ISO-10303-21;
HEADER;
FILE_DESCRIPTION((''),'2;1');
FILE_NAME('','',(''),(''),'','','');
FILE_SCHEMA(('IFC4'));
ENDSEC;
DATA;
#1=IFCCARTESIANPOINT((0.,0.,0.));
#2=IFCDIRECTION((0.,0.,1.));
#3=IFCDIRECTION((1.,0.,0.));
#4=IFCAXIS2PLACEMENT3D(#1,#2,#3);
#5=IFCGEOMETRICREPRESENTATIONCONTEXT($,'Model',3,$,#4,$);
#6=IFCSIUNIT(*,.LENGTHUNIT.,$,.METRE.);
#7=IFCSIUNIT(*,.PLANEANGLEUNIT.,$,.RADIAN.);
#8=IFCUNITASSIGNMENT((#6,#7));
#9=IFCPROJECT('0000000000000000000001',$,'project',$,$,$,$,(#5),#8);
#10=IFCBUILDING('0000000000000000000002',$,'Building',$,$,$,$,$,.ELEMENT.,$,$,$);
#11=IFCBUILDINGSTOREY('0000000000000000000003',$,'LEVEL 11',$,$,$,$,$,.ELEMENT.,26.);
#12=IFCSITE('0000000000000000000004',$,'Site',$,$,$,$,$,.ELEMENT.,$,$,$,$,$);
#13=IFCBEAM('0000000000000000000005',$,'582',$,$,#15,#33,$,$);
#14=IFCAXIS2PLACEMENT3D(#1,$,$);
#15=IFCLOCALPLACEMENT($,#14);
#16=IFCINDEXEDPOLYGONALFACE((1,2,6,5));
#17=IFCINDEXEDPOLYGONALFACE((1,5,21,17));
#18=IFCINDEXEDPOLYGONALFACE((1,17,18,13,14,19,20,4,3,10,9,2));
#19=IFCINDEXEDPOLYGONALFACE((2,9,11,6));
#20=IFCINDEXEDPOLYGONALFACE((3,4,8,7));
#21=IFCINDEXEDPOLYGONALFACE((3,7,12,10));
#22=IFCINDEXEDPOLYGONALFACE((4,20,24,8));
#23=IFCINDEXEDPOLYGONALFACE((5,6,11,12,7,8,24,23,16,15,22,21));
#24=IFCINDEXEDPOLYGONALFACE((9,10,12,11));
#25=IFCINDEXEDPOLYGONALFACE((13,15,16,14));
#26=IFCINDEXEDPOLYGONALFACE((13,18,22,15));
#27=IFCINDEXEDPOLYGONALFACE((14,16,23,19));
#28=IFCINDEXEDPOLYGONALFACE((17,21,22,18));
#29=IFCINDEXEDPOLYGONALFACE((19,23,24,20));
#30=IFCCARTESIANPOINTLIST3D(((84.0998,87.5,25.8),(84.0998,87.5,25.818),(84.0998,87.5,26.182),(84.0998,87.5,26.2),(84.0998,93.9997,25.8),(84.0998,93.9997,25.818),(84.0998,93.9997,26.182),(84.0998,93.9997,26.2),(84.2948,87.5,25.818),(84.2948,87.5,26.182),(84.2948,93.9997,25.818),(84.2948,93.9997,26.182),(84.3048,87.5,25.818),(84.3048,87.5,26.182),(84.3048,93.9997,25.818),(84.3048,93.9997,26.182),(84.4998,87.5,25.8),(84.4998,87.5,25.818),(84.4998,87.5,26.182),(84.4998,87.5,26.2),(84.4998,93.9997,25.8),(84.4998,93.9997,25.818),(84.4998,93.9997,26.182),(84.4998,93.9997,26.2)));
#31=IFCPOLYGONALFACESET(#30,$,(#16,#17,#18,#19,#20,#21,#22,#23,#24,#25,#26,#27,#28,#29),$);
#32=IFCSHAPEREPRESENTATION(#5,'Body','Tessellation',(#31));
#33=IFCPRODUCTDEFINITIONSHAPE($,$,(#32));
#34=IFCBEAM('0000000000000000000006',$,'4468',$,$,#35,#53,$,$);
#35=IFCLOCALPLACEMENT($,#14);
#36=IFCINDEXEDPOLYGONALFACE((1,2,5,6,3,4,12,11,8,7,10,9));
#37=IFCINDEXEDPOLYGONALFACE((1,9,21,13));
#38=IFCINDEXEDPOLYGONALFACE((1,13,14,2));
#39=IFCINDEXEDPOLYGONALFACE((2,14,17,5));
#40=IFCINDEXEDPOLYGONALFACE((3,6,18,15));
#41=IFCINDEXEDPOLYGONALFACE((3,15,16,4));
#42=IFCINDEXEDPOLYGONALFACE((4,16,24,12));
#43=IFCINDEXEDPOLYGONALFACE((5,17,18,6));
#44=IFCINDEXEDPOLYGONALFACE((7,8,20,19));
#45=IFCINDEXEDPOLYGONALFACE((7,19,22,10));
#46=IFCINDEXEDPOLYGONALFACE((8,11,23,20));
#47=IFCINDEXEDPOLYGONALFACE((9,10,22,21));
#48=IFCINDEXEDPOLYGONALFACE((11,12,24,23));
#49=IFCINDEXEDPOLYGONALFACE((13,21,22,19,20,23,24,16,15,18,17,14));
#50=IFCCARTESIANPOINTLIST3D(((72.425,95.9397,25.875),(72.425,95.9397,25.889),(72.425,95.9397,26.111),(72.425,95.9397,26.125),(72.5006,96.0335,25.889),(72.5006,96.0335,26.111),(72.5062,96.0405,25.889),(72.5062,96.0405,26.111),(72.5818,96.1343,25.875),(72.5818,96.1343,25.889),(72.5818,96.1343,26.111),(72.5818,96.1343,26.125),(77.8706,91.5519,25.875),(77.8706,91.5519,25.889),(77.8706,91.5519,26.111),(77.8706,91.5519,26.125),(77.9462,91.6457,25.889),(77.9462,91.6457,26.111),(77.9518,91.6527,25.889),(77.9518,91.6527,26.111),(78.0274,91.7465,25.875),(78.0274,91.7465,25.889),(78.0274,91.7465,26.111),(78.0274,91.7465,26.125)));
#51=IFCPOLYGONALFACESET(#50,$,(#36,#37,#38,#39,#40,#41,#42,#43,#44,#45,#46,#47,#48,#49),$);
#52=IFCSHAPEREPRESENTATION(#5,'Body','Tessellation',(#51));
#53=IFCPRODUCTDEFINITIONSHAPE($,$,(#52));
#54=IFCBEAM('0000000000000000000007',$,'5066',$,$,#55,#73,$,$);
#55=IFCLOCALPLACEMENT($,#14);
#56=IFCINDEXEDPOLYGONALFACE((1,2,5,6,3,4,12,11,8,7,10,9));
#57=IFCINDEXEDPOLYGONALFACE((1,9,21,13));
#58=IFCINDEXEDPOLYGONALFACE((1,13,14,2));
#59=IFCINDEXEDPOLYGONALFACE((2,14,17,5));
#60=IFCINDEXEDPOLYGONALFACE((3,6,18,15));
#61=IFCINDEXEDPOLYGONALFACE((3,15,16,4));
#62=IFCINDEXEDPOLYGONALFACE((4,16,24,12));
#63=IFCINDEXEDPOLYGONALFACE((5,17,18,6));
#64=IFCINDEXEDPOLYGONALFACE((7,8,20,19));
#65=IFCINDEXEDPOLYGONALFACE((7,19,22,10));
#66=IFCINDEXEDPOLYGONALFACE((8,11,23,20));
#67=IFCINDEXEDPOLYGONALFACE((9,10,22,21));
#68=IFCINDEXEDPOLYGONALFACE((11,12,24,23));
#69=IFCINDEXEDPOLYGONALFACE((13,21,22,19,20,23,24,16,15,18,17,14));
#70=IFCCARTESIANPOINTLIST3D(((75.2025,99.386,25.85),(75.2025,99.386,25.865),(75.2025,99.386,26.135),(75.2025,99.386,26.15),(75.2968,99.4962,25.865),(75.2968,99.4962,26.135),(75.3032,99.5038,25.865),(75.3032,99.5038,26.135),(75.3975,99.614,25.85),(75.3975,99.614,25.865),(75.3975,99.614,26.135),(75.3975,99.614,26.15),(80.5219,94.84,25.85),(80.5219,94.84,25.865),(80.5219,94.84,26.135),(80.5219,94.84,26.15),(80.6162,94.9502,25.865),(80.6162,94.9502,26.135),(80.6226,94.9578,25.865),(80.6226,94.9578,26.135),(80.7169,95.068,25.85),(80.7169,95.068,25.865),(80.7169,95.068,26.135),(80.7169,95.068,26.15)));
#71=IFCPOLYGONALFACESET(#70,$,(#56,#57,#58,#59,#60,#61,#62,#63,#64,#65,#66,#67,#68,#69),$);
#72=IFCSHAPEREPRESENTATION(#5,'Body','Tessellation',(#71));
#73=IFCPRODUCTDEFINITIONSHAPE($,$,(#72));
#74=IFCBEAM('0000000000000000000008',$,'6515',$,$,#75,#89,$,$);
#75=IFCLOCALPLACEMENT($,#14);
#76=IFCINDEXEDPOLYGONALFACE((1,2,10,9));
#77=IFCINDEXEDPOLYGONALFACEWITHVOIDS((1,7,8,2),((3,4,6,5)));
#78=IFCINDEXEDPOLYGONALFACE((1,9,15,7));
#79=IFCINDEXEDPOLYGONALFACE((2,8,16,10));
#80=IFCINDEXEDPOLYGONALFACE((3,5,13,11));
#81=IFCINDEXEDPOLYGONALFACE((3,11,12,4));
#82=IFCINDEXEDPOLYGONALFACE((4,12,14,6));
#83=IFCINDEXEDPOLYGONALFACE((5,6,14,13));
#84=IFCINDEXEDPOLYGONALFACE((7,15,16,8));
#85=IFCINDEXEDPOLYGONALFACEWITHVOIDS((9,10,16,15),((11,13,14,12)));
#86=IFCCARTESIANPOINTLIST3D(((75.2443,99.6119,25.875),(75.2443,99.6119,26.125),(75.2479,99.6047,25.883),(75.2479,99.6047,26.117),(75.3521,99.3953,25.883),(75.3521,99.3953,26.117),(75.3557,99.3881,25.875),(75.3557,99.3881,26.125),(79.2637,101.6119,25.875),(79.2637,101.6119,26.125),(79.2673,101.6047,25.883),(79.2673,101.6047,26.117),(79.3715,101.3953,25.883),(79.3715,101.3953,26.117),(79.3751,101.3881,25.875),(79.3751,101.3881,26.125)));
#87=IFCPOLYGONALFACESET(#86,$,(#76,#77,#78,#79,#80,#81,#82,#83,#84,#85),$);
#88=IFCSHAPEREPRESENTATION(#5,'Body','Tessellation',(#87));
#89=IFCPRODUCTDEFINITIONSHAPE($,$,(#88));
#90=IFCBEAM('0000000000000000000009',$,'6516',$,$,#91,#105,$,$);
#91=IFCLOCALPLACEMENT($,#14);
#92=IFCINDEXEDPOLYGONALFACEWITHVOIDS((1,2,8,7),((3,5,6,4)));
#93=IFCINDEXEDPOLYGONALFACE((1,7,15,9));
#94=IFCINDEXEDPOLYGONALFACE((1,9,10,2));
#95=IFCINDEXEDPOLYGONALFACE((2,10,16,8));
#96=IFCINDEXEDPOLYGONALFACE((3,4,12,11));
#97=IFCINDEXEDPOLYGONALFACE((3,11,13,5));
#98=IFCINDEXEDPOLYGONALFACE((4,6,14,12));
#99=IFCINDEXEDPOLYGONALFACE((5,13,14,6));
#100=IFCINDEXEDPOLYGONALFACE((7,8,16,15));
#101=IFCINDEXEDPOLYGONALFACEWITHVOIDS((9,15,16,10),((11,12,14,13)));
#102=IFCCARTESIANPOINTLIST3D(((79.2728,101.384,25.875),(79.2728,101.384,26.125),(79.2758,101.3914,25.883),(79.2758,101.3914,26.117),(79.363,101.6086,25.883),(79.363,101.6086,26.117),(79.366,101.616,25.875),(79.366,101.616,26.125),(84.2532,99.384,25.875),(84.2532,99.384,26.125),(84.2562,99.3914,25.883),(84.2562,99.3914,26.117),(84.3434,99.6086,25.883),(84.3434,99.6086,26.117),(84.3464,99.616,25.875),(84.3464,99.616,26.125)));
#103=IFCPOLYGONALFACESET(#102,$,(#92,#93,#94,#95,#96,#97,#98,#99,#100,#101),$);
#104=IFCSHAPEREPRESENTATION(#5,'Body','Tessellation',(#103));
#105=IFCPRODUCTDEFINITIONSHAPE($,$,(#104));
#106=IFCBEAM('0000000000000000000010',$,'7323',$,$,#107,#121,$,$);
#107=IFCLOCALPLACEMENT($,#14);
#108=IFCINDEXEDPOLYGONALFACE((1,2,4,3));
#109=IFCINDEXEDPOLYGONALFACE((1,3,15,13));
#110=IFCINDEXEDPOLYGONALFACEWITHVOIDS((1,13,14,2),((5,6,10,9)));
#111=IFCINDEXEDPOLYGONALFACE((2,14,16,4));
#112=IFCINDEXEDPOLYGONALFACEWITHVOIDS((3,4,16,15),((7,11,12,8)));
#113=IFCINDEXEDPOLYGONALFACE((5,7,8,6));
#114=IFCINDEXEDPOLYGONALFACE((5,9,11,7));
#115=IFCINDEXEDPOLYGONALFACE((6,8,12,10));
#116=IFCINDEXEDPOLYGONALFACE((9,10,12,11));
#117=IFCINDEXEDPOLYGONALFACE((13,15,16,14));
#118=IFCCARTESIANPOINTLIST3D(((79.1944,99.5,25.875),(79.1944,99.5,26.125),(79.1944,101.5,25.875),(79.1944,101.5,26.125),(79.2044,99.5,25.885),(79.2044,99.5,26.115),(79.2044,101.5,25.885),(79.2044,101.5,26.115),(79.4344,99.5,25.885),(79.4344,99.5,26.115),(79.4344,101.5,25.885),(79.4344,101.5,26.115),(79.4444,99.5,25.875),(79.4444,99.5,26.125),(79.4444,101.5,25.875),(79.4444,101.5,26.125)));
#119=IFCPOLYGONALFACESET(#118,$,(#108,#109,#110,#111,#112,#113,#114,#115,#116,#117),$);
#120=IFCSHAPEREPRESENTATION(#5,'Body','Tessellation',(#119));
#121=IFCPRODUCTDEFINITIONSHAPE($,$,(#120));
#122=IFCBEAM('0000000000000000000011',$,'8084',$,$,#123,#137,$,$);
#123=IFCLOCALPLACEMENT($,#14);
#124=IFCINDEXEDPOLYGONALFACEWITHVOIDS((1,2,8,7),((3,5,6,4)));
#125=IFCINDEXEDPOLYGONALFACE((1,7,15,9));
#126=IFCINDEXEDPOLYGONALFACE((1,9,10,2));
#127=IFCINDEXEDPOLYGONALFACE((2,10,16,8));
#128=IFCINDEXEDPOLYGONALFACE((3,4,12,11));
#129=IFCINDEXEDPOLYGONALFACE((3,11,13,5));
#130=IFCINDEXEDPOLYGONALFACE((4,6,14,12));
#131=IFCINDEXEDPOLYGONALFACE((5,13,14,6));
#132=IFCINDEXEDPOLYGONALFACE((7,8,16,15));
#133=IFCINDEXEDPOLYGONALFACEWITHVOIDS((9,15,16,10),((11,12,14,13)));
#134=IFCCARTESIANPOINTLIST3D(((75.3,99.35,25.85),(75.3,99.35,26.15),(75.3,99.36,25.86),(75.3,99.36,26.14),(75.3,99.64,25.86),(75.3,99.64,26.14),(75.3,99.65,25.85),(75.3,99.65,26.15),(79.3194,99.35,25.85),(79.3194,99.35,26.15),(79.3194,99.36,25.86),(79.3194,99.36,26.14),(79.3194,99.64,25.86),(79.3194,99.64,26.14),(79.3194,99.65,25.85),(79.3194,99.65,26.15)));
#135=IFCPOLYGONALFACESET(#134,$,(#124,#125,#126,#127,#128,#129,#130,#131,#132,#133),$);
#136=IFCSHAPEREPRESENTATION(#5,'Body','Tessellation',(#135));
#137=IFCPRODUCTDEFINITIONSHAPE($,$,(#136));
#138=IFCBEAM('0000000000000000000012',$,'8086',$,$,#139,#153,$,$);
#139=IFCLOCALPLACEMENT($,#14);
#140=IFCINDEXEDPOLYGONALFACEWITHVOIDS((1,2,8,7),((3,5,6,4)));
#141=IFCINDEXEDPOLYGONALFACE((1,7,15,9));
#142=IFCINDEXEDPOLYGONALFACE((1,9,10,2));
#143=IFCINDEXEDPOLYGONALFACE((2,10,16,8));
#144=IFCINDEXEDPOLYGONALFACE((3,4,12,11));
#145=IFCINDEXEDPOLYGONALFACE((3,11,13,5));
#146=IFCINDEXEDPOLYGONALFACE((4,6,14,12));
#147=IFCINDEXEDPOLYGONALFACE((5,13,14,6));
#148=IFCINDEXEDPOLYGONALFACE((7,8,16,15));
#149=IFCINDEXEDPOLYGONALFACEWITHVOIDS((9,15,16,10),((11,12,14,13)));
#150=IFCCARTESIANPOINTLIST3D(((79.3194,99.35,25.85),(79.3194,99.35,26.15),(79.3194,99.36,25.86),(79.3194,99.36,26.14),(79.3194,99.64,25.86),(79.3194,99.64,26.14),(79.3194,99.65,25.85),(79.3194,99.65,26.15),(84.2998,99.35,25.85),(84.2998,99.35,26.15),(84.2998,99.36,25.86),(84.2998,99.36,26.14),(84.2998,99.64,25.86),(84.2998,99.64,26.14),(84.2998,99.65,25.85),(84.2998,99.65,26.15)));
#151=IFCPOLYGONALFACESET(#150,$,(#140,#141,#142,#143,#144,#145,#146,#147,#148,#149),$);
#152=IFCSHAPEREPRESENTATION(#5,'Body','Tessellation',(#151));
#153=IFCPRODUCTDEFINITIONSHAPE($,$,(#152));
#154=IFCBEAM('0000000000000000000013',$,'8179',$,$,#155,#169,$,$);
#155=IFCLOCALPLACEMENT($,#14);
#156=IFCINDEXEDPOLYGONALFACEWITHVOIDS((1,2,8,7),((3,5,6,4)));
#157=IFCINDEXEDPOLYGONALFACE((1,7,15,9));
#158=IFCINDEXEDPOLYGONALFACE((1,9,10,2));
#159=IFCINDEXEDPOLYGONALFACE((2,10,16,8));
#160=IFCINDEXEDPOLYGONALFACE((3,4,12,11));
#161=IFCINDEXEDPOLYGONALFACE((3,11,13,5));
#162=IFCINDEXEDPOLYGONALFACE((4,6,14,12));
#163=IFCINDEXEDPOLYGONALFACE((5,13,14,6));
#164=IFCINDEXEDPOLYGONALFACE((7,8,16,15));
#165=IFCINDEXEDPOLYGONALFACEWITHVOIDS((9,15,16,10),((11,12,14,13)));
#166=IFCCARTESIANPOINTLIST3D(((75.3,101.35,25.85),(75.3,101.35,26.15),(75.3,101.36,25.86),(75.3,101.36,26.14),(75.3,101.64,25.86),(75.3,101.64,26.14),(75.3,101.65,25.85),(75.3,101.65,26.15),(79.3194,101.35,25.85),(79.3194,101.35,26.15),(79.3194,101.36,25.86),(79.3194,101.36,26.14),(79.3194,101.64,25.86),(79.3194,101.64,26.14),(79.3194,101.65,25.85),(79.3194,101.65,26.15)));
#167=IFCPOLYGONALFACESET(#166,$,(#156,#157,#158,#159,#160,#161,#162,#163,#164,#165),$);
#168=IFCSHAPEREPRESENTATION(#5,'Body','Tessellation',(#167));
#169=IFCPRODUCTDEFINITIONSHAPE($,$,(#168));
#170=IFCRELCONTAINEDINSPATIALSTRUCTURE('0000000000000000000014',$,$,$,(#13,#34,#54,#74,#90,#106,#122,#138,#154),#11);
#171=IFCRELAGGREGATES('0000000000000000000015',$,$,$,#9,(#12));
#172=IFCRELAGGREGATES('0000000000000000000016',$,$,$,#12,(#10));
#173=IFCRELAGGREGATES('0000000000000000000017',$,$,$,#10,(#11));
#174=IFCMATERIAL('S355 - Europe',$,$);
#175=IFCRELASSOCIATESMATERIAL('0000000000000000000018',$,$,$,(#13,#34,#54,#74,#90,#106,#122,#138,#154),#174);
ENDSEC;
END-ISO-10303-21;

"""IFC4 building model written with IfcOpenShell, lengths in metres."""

from ifc_helpers import new_model, si_unit, frame, origin_with_axes, origin_2d_with_axis, place, context, project, spatial, hollow_rectangle, i_section, extrude, material, material_profile, profile_set, profile_usage, element, save


model = new_model("IFC4")

# Units and contexts
model_context = context("Model", 3, world=origin_with_axes())
ifc_project = project(units=[si_unit("LENGTHUNIT", "METRE"), si_unit("PLANEANGLEUNIT", "RADIAN")], contexts=[model_context])

# Site, building, storey
site = spatial("IfcSite", under=ifc_project, Name="Site", CompositionType="ELEMENT")
building = spatial("IfcBuilding", under=site, Name="Building", CompositionType="ELEMENT")
storey = spatial("IfcBuildingStorey", under=building, Name="LEVEL 11", CompositionType="ELEMENT", Elevation=26.0)

# Shared definitions
ifc_material = material(Name="S355 - Europe")

# Beams
ifc_material_profile_1 = material_profile(ifc_material, i_section(OverallWidth=0.4, OverallDepth=0.4, WebThickness=0.01, FlangeThickness=0.018, at=origin_2d_with_axis()))
ifc_profile_set_1 = profile_set([ifc_material_profile_1])
ifc_profile_usage_1 = profile_usage(ifc_profile_set_1, cardinal=10)
beam_1_placement = place(None, frame((84.2998, 93.9997, 26.0), z_axis=(0.0, -1.0, 0.0), x_axis=(1.0, 0.0, 0.0)))
element("IfcBeam", 1, at=beam_1_placement, inside=storey, material=ifc_profile_usage_1, Name="582", context=model_context, shape_type="SweptSolid", body=[
    extrude(i_section(OverallWidth=0.4, OverallDepth=0.4, WebThickness=0.01, FlangeThickness=0.018, at=origin_2d_with_axis()), origin_with_axes(), (0.0, 0.0, 1.0), 6.4997),
])
ifc_material_profile_2 = material_profile(ifc_material, i_section(OverallWidth=0.25, OverallDepth=0.25, WebThickness=0.009, FlangeThickness=0.014, at=origin_2d_with_axis()))
ifc_profile_set_2 = profile_set([ifc_material_profile_2])
ifc_profile_usage_2 = profile_usage(ifc_profile_set_2, cardinal=10)
beam_2_placement = place(None, frame((77.949, 91.6492, 26.0), z_axis=(-0.77868, 0.627421, 0.0), x_axis=(-0.626214, -0.779651, 0.0)))
element("IfcBeam", 2, at=beam_2_placement, inside=storey, material=ifc_profile_usage_2, Name="4468", context=model_context, shape_type="SweptSolid", body=[
    extrude(i_section(OverallWidth=0.25, OverallDepth=0.25, WebThickness=0.009, FlangeThickness=0.014, at=origin_2d_with_axis()), origin_with_axes(), (0.0, 0.0, 1.0), 6.9934),
])
ifc_material_profile_3 = material_profile(ifc_material, i_section(OverallWidth=0.3, OverallDepth=0.3, WebThickness=0.01, FlangeThickness=0.015, at=origin_2d_with_axis()))
ifc_profile_set_3 = profile_set([ifc_material_profile_3])
ifc_profile_usage_3 = profile_usage(ifc_profile_set_3, cardinal=10)
beam_3_placement = place(None, frame((80.6194, 94.954, 26.0), z_axis=(-0.760208, 0.64968, 0.0), x_axis=(-0.64968, -0.760208, 0.0)))
element("IfcBeam", 3, at=beam_3_placement, inside=storey, material=ifc_profile_usage_3, Name="5066", context=model_context, shape_type="SweptSolid", body=[
    extrude(i_section(OverallWidth=0.3, OverallDepth=0.3, WebThickness=0.01, FlangeThickness=0.015, at=origin_2d_with_axis()), origin_with_axes(), (0.0, 0.0, 1.0), 6.9973),
])
ifc_material_profile_4 = material_profile(ifc_material, hollow_rectangle(XDim=0.25, YDim=0.25, WallThickness=0.008, at=origin_2d_with_axis()))
ifc_profile_set_4 = profile_set([ifc_material_profile_4])
ifc_profile_usage_4 = profile_usage(ifc_profile_set_4, cardinal=10)
beam_4_placement = place(None, frame((75.3, 99.5, 26.0), z_axis=(0.89529, 0.445484, 0.0), x_axis=(-0.445484, 0.89529, 0.0)))
element("IfcBeam", 4, at=beam_4_placement, inside=storey, material=ifc_profile_usage_4, Name="6515", context=model_context, shape_type="SweptSolid", body=[
    extrude(hollow_rectangle(XDim=0.25, YDim=0.25, WallThickness=0.008, at=origin_2d_with_axis()), origin_with_axes(), (0.0, 0.0, 1.0), 4.4895),
])
ifc_material_profile_5 = material_profile(ifc_material, hollow_rectangle(XDim=0.25, YDim=0.25, WallThickness=0.008, at=origin_2d_with_axis()))
ifc_profile_set_5 = profile_set([ifc_material_profile_5])
ifc_profile_usage_5 = profile_usage(ifc_profile_set_5, cardinal=10)
beam_5_placement = place(None, frame((79.3194, 101.5, 26.0), z_axis=(0.927972, -0.37265, 0.0), x_axis=(0.37265, 0.927972, 0.0)))
element("IfcBeam", 5, at=beam_5_placement, inside=storey, material=ifc_profile_usage_5, Name="6516", context=model_context, shape_type="SweptSolid", body=[
    extrude(hollow_rectangle(XDim=0.25, YDim=0.25, WallThickness=0.008, at=origin_2d_with_axis()), origin_with_axes(), (0.0, 0.0, 1.0), 5.367),
])
ifc_material_profile_6 = material_profile(ifc_material, hollow_rectangle(XDim=0.25, YDim=0.25, WallThickness=0.01, at=origin_2d_with_axis()))
ifc_profile_set_6 = profile_set([ifc_material_profile_6])
ifc_profile_usage_6 = profile_usage(ifc_profile_set_6, cardinal=10)
beam_6_placement = place(None, frame((79.3194, 99.5, 26.0), z_axis=(0.0, 1.0, 0.0), x_axis=(-1.0, 0.0, 0.0)))
element("IfcBeam", 6, at=beam_6_placement, inside=storey, material=ifc_profile_usage_6, Name="7323", context=model_context, shape_type="SweptSolid", body=[
    extrude(hollow_rectangle(XDim=0.25, YDim=0.25, WallThickness=0.01, at=origin_2d_with_axis()), origin_with_axes(), (0.0, 0.0, 1.0), 2.0),
])
ifc_material_profile_7 = material_profile(ifc_material, hollow_rectangle(XDim=0.3, YDim=0.3, WallThickness=0.01, at=origin_2d_with_axis()))
ifc_profile_set_7 = profile_set([ifc_material_profile_7])
ifc_profile_usage_7 = profile_usage(ifc_profile_set_7, cardinal=10)
beam_7_placement = place(None, frame((75.3, 99.5, 26.0), z_axis=(1.0, 0.0, 0.0), x_axis=(0.0, 1.0, 0.0)))
element("IfcBeam", 7, at=beam_7_placement, inside=storey, material=ifc_profile_usage_7, Name="8084", context=model_context, shape_type="SweptSolid", body=[
    extrude(hollow_rectangle(XDim=0.3, YDim=0.3, WallThickness=0.01, at=origin_2d_with_axis()), origin_with_axes(), (0.0, 0.0, 1.0), 4.0194),
])
ifc_material_profile_8 = material_profile(ifc_material, hollow_rectangle(XDim=0.3, YDim=0.3, WallThickness=0.01, at=origin_2d_with_axis()))
ifc_profile_set_8 = profile_set([ifc_material_profile_8])
ifc_profile_usage_8 = profile_usage(ifc_profile_set_8, cardinal=10)
beam_8_placement = place(None, frame((79.3194, 99.5, 26.0), z_axis=(1.0, 0.0, 0.0), x_axis=(0.0, 1.0, 0.0)))
element("IfcBeam", 8, at=beam_8_placement, inside=storey, material=ifc_profile_usage_8, Name="8086", context=model_context, shape_type="SweptSolid", body=[
    extrude(hollow_rectangle(XDim=0.3, YDim=0.3, WallThickness=0.01, at=origin_2d_with_axis()), origin_with_axes(), (0.0, 0.0, 1.0), 4.9804),
])
ifc_material_profile_9 = material_profile(ifc_material, hollow_rectangle(XDim=0.3, YDim=0.3, WallThickness=0.01, at=origin_2d_with_axis()))
ifc_profile_set_9 = profile_set([ifc_material_profile_9])
ifc_profile_usage_9 = profile_usage(ifc_profile_set_9, cardinal=10)
beam_9_placement = place(None, frame((75.3, 101.5, 26.0), z_axis=(1.0, 0.0, 0.0), x_axis=(0.0, 1.0, 0.0)))
element("IfcBeam", 9, at=beam_9_placement, inside=storey, material=ifc_profile_usage_9, Name="8179", context=model_context, shape_type="SweptSolid", body=[
    extrude(hollow_rectangle(XDim=0.3, YDim=0.3, WallThickness=0.01, at=origin_2d_with_axis()), origin_with_axes(), (0.0, 0.0, 1.0), 4.0194),
])

save(model, "model.ifc")
